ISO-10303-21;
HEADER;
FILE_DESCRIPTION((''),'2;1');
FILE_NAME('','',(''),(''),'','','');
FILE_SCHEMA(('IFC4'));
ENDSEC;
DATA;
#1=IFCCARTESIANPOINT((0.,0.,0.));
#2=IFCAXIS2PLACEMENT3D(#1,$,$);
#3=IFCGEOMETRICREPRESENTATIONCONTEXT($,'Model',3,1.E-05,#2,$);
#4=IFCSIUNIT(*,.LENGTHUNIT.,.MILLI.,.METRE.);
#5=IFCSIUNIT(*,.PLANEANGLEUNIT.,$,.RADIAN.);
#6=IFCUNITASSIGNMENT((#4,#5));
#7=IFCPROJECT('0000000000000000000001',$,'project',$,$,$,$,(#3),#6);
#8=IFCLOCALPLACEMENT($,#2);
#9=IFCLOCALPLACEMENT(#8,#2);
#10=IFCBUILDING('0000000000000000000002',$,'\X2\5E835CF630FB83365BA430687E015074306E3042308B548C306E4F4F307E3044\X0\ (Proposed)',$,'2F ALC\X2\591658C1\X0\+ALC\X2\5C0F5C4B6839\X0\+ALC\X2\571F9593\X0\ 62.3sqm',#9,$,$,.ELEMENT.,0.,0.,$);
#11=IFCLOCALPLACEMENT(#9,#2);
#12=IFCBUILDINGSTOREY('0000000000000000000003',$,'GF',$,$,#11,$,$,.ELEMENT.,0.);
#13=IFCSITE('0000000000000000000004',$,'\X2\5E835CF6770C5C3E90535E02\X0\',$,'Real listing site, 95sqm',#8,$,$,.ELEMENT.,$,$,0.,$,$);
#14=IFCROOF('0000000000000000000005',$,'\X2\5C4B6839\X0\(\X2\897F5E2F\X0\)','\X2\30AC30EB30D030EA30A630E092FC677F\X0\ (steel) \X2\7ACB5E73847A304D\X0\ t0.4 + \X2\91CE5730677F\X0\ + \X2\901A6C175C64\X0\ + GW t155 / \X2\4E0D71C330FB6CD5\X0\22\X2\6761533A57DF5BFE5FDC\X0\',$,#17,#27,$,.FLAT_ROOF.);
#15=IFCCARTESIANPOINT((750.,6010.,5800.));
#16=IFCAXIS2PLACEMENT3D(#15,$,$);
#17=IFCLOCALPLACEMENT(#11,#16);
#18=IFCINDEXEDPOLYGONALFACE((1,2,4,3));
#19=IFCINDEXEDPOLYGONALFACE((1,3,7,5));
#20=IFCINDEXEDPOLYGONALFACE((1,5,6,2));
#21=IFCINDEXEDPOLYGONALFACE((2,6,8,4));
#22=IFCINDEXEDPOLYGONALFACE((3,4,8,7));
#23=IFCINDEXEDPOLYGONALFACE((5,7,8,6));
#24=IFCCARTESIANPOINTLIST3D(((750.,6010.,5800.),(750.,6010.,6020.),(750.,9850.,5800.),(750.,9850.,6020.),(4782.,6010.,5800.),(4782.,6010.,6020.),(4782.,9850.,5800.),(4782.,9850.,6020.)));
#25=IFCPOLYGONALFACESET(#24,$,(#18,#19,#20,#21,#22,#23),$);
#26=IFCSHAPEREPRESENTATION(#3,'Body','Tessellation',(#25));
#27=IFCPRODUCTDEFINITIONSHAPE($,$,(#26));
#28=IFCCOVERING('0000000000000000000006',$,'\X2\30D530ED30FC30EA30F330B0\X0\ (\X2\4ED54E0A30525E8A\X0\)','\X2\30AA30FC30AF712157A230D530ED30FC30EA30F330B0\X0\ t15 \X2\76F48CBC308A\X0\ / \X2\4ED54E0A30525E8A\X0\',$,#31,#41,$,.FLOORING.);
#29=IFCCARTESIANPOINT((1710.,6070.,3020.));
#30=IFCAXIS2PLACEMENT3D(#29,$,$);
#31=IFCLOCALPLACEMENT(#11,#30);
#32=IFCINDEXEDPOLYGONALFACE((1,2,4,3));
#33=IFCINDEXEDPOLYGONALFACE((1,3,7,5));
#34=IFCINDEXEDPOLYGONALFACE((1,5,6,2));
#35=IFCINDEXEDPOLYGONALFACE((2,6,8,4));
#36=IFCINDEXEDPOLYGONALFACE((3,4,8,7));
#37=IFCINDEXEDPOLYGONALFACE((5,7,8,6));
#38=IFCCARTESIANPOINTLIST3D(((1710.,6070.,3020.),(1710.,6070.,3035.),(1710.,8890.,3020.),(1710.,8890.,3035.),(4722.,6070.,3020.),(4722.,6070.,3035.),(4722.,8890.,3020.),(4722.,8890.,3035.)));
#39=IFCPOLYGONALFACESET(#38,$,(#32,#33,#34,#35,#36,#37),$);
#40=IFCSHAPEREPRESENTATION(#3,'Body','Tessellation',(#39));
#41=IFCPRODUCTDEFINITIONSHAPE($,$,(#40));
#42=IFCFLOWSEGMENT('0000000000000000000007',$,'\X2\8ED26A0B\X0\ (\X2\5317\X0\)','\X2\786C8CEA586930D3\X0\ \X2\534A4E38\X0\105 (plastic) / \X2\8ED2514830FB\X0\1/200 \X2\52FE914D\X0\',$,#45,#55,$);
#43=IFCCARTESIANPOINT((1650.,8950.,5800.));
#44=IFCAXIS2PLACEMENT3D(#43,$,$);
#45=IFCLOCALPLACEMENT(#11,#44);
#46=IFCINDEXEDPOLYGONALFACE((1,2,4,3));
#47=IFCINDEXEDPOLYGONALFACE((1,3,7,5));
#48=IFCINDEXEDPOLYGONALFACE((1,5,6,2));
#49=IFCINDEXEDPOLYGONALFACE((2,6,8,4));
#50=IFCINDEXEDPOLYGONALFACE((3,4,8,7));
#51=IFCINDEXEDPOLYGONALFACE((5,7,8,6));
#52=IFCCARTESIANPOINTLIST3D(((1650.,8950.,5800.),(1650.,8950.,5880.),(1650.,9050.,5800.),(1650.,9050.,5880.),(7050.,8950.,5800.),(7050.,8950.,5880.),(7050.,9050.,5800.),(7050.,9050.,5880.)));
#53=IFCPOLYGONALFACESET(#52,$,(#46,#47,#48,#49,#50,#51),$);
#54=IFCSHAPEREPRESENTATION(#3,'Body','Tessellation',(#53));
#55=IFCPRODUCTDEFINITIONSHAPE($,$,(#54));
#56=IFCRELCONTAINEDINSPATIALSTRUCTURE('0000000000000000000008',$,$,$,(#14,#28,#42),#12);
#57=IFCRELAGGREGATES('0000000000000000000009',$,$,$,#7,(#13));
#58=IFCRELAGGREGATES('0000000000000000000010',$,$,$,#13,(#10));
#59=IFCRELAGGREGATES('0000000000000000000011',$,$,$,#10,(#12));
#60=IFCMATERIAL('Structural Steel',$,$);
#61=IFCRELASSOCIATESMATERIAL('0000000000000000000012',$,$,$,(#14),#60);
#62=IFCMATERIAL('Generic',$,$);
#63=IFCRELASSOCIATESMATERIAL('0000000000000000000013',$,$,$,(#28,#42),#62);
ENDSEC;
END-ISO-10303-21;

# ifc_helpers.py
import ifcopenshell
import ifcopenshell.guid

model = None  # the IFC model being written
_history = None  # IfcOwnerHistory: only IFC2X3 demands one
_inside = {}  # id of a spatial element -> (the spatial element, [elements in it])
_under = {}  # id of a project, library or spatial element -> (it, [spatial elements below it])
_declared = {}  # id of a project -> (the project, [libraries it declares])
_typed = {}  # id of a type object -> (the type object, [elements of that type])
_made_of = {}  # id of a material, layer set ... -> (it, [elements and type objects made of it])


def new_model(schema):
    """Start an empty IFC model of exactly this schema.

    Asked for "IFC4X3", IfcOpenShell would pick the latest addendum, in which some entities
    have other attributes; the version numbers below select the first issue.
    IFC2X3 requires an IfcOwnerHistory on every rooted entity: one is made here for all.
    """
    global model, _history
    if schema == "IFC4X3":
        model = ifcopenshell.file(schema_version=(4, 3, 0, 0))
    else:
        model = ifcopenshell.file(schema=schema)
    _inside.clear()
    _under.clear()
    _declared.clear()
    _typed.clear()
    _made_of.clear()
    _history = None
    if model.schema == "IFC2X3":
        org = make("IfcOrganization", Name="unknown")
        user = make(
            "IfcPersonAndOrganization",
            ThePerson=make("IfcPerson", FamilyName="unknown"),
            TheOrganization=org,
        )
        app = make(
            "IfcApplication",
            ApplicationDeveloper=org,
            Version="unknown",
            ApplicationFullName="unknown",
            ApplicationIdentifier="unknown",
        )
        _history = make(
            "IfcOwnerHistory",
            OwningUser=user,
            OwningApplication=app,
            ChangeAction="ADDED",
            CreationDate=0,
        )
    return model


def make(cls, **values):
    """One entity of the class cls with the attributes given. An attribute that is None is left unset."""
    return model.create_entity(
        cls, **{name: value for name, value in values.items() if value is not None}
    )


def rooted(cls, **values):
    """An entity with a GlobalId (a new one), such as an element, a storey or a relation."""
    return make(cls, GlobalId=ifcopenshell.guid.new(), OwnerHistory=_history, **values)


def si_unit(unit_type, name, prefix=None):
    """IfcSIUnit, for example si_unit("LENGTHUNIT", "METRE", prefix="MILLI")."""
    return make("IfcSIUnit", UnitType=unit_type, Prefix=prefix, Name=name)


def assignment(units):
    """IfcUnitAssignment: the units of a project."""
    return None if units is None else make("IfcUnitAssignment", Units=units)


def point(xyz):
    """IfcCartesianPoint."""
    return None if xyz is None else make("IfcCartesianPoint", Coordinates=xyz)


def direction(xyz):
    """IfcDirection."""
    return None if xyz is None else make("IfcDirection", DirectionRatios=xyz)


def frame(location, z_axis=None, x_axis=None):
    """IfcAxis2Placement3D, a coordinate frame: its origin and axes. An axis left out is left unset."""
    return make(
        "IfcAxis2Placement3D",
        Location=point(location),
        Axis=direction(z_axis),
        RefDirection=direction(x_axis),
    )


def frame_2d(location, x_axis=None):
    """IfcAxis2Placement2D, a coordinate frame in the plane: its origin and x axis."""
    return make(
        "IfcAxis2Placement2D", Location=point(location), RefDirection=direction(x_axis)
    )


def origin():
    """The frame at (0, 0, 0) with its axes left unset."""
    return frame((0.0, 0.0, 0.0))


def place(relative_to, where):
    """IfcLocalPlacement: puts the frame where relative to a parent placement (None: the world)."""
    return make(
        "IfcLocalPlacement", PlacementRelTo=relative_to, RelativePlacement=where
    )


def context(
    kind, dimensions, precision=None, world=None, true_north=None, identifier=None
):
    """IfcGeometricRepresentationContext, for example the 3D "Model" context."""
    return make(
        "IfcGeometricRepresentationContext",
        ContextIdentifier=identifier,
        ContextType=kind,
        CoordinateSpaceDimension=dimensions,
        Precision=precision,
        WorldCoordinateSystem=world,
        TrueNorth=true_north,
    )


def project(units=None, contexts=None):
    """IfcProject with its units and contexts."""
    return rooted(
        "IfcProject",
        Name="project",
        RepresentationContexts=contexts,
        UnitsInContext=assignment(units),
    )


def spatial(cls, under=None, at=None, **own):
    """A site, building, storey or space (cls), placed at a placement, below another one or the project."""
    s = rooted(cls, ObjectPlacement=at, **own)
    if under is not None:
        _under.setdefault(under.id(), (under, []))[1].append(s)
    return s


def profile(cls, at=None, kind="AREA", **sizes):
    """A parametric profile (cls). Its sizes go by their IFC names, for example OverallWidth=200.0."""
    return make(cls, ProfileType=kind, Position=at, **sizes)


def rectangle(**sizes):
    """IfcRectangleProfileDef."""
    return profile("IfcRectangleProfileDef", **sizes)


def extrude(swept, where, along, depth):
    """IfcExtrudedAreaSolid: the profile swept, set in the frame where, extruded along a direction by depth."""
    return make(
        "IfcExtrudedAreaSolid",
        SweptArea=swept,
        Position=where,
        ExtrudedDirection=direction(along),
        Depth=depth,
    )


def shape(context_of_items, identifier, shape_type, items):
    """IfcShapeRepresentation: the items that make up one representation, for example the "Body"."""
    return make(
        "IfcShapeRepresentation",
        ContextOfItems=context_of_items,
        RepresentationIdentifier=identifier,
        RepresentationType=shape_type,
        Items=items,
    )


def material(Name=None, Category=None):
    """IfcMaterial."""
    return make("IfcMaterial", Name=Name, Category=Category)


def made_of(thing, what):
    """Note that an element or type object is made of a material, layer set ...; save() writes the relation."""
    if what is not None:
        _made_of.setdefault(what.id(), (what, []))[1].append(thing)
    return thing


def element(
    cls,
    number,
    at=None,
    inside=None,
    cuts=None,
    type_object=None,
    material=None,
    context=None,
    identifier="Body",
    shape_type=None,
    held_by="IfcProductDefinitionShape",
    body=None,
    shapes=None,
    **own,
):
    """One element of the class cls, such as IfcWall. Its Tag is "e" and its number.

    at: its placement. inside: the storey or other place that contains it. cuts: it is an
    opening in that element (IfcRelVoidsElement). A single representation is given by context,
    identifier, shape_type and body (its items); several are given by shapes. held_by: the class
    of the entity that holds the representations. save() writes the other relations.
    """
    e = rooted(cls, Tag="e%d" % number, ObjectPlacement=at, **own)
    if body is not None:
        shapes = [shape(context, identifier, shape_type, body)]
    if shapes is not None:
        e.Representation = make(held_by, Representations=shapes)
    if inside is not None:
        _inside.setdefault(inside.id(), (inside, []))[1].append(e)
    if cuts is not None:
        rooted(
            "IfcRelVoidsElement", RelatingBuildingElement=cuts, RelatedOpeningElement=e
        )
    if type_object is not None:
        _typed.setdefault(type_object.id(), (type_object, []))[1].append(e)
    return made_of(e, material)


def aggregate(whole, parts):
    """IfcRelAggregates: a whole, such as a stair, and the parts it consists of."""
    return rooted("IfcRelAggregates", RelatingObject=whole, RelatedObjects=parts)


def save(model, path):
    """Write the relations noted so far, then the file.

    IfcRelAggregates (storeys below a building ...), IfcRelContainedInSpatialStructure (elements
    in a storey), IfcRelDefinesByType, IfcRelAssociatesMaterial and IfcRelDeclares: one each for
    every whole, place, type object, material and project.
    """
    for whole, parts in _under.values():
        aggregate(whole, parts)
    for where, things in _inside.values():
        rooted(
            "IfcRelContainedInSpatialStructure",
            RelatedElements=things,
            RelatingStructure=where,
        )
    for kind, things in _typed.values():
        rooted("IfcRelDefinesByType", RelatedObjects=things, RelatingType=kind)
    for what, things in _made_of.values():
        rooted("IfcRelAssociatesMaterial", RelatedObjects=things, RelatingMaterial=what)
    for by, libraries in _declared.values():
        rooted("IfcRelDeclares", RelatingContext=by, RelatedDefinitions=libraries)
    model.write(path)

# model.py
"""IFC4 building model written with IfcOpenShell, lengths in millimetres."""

from ifc_helpers import new_model, si_unit, frame, frame_2d, origin, place, context, project, spatial, rectangle, extrude, material, element, save


model = new_model("IFC4")

# Units and contexts
model_context = context("Model", 3, precision=1e-05, world=origin())
ifc_project = project(units=[si_unit("LENGTHUNIT", "METRE", prefix="MILLI"), si_unit("PLANEANGLEUNIT", "RADIAN")], contexts=[model_context])

# Site, building, storey
site_placement = place(None, origin())
site = spatial("IfcSite", under=ifc_project, at=site_placement, Name="広島県尾道市", ObjectType="Real listing site, 95sqm", CompositionType="ELEMENT", RefElevation=0.0)
building_placement = place(site_placement, origin())
building = spatial("IfcBuilding", under=site, at=building_placement, Name="広島・茶室と縁側のある和の住まい (Proposed)", ObjectType="2F ALC外壁+ALC小屋根+ALC土間 62.3sqm", CompositionType="ELEMENT", ElevationOfRefHeight=0.0, ElevationOfTerrain=0.0)
storey_placement = place(building_placement, origin())
storey = spatial("IfcBuildingStorey", under=building, at=storey_placement, Name="GF", CompositionType="ELEMENT", Elevation=0.0)

# Roof
ifc_material_1 = material(Name="Structural Steel")
for number, where, name in (
    (1, (750.0, 6010.0, 5800.0), "屋根(西帯)"),
):
    element("IfcRoof", number, at=place(storey_placement, frame(where)), inside=storey, material=ifc_material_1, Name=name, Description="ガルバリウム鋼板 (steel) 立平葺き t0.4 + 野地板 + 通気層 + GW t155 / 不燃・法22条区域対応", PredefinedType="FLAT_ROOF", context=model_context, shape_type="SweptSolid", body=[
        extrude(rectangle(XDim=4032.0, YDim=3840.0, at=frame_2d((2016.0, 1920.0))), frame((750.0, 6010.0, 5800.0)), (0.0, 0.0, 1.0), 220.0),
    ])

# Covering
ifc_material_2 = material(Name="Generic")
covering_placement = place(storey_placement, frame((1710.0, 6070.0, 3020.0)))
element("IfcCovering", 2, at=covering_placement, inside=storey, material=ifc_material_2, Name="フローリング (仕上げ床)", Description="オーク無垢フローリング t15 直貼り / 仕上げ床", PredefinedType="FLOORING", context=model_context, shape_type="SweptSolid", body=[
    extrude(rectangle(XDim=3012.0, YDim=2820.0, at=frame_2d((1506.0, 1410.0))), frame((1710.0, 6070.0, 3020.0)), (0.0, 0.0, 1.0), 15.0),
])

# Flow segment
flow_segment_placement = place(storey_placement, frame((1650.0, 8950.0, 5800.0)))
element("IfcFlowSegment", 3, at=flow_segment_placement, inside=storey, material=ifc_material_2, Name="軒樋 (北)", Description="硬質塩ビ 半丸105 (plastic) / 軒先・1/200 勾配", context=model_context, shape_type="SweptSolid", body=[
    extrude(rectangle(XDim=5400.0, YDim=100.0, at=frame_2d((2700.0, 50.0))), frame((1650.0, 8950.0, 5800.0)), (0.0, 0.0, 1.0), 80.0),
])

save(model, "model.ifc")
